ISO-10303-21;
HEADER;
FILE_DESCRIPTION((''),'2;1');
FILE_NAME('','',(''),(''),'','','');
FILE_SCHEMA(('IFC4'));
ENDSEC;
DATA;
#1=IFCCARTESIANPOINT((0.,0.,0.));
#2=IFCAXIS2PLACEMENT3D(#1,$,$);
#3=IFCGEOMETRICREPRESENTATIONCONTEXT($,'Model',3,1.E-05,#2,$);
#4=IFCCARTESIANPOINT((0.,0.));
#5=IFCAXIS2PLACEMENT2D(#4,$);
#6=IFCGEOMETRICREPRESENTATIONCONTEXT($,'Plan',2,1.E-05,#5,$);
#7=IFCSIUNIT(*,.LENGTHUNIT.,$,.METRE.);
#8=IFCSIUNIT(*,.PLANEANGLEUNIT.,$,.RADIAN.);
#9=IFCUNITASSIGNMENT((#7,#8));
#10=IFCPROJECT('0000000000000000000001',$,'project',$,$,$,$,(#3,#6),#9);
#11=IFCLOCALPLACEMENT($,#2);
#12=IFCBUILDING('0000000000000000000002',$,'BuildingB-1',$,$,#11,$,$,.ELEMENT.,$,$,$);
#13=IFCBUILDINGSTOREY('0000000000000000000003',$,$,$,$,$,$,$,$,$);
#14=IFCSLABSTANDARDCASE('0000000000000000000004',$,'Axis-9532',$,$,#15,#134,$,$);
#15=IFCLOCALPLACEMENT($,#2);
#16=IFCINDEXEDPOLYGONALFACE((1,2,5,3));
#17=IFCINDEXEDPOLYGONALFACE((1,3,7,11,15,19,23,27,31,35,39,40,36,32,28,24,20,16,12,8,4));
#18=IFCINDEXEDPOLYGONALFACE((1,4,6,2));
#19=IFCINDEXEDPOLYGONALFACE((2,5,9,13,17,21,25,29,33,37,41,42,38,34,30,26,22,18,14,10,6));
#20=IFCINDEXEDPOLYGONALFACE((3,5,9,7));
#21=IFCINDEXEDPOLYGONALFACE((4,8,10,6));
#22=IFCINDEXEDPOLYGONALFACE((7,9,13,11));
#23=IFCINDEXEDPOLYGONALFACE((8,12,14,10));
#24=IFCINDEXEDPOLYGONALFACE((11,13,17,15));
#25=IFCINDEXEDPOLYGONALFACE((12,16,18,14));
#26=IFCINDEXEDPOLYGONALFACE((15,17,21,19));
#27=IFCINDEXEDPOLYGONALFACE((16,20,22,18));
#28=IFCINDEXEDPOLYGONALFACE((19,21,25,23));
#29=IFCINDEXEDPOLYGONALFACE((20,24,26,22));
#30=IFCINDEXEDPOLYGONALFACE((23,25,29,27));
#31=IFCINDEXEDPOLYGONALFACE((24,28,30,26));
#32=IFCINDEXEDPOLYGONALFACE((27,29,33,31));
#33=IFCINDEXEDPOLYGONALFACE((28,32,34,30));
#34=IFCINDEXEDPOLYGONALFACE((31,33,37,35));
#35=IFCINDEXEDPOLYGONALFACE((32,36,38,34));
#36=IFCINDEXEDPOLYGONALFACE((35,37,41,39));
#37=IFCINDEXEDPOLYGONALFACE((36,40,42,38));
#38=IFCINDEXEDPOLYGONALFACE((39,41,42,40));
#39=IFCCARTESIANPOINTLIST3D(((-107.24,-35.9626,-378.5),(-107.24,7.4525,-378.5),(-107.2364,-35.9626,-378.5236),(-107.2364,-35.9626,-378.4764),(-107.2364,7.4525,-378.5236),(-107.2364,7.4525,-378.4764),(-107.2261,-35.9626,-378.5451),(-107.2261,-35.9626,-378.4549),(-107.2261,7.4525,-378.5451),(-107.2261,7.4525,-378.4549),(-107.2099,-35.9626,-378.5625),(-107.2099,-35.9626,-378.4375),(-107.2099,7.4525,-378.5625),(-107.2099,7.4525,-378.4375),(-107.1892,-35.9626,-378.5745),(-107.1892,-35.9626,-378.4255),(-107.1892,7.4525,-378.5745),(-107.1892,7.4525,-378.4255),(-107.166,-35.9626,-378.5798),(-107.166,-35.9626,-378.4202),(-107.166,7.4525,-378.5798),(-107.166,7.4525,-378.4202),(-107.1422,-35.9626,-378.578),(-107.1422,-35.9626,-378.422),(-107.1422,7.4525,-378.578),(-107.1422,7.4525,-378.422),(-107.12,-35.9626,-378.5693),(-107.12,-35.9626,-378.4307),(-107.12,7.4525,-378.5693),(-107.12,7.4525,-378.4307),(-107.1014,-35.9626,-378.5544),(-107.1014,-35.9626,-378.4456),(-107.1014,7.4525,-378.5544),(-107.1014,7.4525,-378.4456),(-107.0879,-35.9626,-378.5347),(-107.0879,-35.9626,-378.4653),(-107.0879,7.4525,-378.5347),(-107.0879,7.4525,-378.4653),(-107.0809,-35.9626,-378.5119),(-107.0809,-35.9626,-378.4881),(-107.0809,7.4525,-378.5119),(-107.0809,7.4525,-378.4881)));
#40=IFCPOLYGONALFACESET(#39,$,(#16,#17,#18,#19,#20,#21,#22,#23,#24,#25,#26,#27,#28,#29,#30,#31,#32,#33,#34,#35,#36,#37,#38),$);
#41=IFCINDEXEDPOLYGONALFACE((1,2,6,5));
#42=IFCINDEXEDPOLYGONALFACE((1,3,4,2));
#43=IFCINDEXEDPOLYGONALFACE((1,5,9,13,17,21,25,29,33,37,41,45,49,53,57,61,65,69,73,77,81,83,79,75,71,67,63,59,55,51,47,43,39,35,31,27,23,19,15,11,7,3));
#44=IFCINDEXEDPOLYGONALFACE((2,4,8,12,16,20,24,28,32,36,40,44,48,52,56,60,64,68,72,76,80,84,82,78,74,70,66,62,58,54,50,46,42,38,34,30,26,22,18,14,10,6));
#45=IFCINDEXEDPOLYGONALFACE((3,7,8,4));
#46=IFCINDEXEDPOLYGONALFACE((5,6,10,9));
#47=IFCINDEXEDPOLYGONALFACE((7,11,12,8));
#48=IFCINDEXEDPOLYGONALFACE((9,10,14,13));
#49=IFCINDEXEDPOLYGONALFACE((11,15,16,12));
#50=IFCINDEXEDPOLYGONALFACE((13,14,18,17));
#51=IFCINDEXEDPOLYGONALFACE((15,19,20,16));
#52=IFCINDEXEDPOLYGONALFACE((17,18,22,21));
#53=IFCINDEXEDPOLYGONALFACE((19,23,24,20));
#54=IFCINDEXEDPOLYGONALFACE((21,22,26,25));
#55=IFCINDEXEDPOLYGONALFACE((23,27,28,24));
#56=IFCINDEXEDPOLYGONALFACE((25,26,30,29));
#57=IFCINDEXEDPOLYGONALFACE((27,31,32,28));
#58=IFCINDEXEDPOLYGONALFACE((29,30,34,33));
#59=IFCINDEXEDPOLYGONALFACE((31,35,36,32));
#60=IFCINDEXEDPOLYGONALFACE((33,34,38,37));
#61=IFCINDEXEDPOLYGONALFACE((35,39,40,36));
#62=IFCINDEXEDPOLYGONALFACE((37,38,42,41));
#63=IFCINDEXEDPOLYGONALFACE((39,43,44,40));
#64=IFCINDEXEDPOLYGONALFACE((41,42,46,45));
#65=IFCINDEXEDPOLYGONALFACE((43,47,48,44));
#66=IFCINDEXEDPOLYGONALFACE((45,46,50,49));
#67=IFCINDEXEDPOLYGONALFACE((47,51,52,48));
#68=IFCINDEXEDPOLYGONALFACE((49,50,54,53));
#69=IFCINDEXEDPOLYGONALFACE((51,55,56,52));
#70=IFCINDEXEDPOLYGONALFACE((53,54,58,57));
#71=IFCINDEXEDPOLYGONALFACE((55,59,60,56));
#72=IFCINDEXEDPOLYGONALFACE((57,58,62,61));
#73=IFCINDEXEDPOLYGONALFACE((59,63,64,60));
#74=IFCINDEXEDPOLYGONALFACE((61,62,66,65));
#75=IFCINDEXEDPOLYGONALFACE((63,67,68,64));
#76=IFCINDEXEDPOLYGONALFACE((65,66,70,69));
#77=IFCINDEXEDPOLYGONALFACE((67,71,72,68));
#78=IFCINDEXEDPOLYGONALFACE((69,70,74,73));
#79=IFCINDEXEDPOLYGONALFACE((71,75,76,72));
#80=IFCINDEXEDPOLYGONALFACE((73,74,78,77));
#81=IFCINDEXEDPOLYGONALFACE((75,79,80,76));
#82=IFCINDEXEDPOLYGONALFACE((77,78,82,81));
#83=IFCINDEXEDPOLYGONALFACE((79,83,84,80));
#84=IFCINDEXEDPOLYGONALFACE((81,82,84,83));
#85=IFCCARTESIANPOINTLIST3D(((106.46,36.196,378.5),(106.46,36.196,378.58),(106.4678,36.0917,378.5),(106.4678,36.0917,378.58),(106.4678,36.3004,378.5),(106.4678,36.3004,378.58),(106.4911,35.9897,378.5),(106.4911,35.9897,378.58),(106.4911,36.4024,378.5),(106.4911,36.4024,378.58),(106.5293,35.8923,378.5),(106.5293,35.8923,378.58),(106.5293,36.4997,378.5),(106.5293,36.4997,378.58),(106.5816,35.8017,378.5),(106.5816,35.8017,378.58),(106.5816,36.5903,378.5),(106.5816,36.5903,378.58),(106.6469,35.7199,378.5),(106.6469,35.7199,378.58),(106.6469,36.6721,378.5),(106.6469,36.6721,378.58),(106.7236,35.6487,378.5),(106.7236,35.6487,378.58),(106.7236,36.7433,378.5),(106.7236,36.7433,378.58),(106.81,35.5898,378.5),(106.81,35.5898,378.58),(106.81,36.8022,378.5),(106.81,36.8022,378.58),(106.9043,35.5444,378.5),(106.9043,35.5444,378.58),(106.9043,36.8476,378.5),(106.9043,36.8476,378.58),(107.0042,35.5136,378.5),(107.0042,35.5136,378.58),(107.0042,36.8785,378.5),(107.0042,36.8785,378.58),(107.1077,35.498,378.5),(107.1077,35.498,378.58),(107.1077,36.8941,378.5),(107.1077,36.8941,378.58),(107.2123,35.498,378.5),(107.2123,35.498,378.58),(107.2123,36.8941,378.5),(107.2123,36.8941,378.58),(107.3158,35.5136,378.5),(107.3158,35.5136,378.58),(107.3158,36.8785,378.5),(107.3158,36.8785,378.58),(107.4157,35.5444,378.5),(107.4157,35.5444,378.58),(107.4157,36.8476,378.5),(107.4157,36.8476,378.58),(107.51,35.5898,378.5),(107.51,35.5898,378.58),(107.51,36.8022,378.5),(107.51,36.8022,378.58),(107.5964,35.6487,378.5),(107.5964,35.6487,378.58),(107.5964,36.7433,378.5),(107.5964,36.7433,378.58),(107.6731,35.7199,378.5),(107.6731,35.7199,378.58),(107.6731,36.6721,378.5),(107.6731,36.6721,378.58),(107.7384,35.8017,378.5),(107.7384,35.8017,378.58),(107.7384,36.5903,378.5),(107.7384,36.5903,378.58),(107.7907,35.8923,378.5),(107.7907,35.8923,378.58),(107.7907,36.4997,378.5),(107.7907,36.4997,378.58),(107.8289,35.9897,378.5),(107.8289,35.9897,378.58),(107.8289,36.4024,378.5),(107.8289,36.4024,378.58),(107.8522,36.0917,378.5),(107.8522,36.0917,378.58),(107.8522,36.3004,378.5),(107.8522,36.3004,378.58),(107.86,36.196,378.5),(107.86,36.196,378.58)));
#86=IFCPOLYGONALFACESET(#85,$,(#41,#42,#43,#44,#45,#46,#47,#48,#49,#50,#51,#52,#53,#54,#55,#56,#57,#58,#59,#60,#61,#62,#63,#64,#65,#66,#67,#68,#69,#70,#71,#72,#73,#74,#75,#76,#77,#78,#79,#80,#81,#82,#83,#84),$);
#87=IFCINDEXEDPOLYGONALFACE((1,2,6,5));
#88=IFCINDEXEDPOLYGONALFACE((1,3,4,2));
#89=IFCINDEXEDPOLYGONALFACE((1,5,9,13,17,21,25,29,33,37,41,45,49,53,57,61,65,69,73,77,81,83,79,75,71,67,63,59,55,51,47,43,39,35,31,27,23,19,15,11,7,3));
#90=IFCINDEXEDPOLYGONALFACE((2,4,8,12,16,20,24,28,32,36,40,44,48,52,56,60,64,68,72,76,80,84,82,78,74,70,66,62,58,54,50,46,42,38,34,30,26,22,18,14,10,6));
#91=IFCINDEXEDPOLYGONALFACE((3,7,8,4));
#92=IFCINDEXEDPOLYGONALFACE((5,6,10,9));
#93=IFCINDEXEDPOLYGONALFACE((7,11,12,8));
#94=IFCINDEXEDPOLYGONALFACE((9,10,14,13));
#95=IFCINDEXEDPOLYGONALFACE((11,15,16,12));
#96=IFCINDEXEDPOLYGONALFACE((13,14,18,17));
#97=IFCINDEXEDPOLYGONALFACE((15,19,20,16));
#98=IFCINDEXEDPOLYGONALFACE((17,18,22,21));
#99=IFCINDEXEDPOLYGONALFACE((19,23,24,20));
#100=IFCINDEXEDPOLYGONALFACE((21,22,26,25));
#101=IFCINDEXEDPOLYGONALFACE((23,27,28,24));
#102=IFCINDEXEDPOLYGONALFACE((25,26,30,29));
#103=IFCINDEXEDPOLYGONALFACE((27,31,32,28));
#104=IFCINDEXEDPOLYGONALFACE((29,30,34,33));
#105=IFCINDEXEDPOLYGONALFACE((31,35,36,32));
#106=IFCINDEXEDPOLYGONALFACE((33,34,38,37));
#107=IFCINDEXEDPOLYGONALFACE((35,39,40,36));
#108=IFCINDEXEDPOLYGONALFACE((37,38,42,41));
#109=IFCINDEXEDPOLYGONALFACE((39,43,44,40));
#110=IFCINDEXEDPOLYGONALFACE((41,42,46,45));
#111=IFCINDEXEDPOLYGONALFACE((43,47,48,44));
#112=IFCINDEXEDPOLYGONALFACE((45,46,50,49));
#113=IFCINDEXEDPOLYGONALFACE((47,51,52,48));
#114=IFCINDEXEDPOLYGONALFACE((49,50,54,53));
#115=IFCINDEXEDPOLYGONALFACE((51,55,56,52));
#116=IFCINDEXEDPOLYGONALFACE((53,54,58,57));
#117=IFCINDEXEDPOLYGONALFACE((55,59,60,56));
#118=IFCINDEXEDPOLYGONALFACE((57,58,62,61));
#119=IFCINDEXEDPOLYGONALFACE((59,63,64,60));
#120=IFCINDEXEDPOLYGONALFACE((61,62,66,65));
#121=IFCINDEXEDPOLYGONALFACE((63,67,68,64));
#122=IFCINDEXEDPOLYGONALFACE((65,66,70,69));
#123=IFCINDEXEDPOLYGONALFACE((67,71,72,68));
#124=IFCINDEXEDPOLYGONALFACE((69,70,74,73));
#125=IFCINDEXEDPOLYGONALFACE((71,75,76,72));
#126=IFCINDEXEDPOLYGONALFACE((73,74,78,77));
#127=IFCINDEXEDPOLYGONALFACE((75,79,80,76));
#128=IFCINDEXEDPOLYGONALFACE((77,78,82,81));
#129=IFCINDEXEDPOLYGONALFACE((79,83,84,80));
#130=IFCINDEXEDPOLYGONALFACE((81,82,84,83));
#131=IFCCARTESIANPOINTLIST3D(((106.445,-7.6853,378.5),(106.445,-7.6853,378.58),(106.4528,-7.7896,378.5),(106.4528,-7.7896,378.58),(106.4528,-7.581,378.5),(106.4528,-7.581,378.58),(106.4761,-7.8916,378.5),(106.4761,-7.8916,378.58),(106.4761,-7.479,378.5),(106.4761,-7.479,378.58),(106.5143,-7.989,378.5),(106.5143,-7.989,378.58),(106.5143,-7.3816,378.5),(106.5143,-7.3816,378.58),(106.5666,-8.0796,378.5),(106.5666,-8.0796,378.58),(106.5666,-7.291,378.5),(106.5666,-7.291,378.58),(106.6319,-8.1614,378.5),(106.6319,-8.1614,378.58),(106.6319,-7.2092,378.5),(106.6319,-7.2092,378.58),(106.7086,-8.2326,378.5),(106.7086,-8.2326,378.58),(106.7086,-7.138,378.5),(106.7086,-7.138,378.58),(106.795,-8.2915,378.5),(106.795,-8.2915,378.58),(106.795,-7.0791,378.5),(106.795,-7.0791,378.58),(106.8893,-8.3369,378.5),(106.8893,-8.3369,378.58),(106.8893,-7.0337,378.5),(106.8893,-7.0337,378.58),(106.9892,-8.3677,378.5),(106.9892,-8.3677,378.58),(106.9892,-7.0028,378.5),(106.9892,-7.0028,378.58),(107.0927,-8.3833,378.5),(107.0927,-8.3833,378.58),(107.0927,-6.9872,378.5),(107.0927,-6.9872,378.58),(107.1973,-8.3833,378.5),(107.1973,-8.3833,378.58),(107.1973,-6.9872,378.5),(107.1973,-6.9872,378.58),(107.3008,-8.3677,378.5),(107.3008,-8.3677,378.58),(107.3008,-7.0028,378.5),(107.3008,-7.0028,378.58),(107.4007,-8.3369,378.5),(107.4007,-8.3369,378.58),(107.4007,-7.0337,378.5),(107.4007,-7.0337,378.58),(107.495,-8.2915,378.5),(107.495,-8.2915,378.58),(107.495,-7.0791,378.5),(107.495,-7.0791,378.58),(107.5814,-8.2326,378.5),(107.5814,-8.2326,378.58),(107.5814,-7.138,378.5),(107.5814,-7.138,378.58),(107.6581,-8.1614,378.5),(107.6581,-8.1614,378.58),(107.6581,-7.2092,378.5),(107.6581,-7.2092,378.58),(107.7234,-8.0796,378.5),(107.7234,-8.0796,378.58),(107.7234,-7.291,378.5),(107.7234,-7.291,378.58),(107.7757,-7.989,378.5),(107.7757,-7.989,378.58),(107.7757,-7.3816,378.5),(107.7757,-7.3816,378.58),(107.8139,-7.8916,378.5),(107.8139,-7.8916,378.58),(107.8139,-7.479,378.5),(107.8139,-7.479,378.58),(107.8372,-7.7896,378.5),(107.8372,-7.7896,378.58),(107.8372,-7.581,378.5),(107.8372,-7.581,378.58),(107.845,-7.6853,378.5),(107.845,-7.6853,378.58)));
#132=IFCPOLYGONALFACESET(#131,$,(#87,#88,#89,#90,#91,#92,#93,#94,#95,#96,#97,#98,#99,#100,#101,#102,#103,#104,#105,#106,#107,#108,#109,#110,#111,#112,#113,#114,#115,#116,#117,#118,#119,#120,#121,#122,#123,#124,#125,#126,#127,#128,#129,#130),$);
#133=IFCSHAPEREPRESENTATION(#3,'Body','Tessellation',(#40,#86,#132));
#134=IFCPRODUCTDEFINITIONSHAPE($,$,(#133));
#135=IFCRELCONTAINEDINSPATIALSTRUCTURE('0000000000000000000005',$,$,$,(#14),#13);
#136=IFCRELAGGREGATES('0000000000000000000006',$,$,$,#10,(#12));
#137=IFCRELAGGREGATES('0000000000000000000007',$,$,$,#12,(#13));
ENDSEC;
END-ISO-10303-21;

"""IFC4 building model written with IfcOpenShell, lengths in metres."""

from ifc_helpers import new_model, entity, si_unit, frame, origin, origin_2d, place, context, project, spatial, circle, extrude, element, save


model = new_model("IFC4")

# Units and contexts
model_context = context("Model", 3, precision=1e-05, world=origin())
plan_context = context("Plan", 2, precision=1e-05, world=origin_2d())
ifc_project = project(units=[si_unit("LENGTHUNIT", "METRE"), si_unit("PLANEANGLEUNIT", "RADIAN")], contexts=[model_context, plan_context])

# Building, storey
building_placement = place(None, origin())
building = spatial("IfcBuilding", under=ifc_project, at=building_placement, Name="BuildingB-1", CompositionType="ELEMENT")
storey = spatial("IfcBuildingStorey", under=building)

# Slab
element("IfcSlabStandardCase", 1, inside=storey, Name="Axis-9532", context=model_context, shape_type="AdvancedSweptSolid", body=[
    entity("IfcSurfaceCurveSweptAreaSolid", entity("IfcCircleProfileDef", "AREA", None, None, 0.08), None, entity("IfcPolyline", [entity("IfcCartesianPoint", [107.16, 35.9626, 378.5]), entity("IfcCartesianPoint", [107.16, -7.4525, 378.5])]), None, None, entity("IfcPlane", entity("IfcAxis2Placement3D", entity("IfcCartesianPoint", [107.16, 35.9626, 378.5]), entity("IfcDirection", [0.0, 0.0, 1.0]), entity("IfcDirection", [1.0, 0.0, 0.0])))),
    extrude(circle(Radius=0.7), frame((107.16, 36.196, 378.5)), (0.0, 0.0, 1.0), 0.08),
    extrude(circle(Radius=0.7), frame((107.145, -7.6853, 378.5)), (0.0, 0.0, 1.0), 0.08),
])

save(model, "model.ifc")
